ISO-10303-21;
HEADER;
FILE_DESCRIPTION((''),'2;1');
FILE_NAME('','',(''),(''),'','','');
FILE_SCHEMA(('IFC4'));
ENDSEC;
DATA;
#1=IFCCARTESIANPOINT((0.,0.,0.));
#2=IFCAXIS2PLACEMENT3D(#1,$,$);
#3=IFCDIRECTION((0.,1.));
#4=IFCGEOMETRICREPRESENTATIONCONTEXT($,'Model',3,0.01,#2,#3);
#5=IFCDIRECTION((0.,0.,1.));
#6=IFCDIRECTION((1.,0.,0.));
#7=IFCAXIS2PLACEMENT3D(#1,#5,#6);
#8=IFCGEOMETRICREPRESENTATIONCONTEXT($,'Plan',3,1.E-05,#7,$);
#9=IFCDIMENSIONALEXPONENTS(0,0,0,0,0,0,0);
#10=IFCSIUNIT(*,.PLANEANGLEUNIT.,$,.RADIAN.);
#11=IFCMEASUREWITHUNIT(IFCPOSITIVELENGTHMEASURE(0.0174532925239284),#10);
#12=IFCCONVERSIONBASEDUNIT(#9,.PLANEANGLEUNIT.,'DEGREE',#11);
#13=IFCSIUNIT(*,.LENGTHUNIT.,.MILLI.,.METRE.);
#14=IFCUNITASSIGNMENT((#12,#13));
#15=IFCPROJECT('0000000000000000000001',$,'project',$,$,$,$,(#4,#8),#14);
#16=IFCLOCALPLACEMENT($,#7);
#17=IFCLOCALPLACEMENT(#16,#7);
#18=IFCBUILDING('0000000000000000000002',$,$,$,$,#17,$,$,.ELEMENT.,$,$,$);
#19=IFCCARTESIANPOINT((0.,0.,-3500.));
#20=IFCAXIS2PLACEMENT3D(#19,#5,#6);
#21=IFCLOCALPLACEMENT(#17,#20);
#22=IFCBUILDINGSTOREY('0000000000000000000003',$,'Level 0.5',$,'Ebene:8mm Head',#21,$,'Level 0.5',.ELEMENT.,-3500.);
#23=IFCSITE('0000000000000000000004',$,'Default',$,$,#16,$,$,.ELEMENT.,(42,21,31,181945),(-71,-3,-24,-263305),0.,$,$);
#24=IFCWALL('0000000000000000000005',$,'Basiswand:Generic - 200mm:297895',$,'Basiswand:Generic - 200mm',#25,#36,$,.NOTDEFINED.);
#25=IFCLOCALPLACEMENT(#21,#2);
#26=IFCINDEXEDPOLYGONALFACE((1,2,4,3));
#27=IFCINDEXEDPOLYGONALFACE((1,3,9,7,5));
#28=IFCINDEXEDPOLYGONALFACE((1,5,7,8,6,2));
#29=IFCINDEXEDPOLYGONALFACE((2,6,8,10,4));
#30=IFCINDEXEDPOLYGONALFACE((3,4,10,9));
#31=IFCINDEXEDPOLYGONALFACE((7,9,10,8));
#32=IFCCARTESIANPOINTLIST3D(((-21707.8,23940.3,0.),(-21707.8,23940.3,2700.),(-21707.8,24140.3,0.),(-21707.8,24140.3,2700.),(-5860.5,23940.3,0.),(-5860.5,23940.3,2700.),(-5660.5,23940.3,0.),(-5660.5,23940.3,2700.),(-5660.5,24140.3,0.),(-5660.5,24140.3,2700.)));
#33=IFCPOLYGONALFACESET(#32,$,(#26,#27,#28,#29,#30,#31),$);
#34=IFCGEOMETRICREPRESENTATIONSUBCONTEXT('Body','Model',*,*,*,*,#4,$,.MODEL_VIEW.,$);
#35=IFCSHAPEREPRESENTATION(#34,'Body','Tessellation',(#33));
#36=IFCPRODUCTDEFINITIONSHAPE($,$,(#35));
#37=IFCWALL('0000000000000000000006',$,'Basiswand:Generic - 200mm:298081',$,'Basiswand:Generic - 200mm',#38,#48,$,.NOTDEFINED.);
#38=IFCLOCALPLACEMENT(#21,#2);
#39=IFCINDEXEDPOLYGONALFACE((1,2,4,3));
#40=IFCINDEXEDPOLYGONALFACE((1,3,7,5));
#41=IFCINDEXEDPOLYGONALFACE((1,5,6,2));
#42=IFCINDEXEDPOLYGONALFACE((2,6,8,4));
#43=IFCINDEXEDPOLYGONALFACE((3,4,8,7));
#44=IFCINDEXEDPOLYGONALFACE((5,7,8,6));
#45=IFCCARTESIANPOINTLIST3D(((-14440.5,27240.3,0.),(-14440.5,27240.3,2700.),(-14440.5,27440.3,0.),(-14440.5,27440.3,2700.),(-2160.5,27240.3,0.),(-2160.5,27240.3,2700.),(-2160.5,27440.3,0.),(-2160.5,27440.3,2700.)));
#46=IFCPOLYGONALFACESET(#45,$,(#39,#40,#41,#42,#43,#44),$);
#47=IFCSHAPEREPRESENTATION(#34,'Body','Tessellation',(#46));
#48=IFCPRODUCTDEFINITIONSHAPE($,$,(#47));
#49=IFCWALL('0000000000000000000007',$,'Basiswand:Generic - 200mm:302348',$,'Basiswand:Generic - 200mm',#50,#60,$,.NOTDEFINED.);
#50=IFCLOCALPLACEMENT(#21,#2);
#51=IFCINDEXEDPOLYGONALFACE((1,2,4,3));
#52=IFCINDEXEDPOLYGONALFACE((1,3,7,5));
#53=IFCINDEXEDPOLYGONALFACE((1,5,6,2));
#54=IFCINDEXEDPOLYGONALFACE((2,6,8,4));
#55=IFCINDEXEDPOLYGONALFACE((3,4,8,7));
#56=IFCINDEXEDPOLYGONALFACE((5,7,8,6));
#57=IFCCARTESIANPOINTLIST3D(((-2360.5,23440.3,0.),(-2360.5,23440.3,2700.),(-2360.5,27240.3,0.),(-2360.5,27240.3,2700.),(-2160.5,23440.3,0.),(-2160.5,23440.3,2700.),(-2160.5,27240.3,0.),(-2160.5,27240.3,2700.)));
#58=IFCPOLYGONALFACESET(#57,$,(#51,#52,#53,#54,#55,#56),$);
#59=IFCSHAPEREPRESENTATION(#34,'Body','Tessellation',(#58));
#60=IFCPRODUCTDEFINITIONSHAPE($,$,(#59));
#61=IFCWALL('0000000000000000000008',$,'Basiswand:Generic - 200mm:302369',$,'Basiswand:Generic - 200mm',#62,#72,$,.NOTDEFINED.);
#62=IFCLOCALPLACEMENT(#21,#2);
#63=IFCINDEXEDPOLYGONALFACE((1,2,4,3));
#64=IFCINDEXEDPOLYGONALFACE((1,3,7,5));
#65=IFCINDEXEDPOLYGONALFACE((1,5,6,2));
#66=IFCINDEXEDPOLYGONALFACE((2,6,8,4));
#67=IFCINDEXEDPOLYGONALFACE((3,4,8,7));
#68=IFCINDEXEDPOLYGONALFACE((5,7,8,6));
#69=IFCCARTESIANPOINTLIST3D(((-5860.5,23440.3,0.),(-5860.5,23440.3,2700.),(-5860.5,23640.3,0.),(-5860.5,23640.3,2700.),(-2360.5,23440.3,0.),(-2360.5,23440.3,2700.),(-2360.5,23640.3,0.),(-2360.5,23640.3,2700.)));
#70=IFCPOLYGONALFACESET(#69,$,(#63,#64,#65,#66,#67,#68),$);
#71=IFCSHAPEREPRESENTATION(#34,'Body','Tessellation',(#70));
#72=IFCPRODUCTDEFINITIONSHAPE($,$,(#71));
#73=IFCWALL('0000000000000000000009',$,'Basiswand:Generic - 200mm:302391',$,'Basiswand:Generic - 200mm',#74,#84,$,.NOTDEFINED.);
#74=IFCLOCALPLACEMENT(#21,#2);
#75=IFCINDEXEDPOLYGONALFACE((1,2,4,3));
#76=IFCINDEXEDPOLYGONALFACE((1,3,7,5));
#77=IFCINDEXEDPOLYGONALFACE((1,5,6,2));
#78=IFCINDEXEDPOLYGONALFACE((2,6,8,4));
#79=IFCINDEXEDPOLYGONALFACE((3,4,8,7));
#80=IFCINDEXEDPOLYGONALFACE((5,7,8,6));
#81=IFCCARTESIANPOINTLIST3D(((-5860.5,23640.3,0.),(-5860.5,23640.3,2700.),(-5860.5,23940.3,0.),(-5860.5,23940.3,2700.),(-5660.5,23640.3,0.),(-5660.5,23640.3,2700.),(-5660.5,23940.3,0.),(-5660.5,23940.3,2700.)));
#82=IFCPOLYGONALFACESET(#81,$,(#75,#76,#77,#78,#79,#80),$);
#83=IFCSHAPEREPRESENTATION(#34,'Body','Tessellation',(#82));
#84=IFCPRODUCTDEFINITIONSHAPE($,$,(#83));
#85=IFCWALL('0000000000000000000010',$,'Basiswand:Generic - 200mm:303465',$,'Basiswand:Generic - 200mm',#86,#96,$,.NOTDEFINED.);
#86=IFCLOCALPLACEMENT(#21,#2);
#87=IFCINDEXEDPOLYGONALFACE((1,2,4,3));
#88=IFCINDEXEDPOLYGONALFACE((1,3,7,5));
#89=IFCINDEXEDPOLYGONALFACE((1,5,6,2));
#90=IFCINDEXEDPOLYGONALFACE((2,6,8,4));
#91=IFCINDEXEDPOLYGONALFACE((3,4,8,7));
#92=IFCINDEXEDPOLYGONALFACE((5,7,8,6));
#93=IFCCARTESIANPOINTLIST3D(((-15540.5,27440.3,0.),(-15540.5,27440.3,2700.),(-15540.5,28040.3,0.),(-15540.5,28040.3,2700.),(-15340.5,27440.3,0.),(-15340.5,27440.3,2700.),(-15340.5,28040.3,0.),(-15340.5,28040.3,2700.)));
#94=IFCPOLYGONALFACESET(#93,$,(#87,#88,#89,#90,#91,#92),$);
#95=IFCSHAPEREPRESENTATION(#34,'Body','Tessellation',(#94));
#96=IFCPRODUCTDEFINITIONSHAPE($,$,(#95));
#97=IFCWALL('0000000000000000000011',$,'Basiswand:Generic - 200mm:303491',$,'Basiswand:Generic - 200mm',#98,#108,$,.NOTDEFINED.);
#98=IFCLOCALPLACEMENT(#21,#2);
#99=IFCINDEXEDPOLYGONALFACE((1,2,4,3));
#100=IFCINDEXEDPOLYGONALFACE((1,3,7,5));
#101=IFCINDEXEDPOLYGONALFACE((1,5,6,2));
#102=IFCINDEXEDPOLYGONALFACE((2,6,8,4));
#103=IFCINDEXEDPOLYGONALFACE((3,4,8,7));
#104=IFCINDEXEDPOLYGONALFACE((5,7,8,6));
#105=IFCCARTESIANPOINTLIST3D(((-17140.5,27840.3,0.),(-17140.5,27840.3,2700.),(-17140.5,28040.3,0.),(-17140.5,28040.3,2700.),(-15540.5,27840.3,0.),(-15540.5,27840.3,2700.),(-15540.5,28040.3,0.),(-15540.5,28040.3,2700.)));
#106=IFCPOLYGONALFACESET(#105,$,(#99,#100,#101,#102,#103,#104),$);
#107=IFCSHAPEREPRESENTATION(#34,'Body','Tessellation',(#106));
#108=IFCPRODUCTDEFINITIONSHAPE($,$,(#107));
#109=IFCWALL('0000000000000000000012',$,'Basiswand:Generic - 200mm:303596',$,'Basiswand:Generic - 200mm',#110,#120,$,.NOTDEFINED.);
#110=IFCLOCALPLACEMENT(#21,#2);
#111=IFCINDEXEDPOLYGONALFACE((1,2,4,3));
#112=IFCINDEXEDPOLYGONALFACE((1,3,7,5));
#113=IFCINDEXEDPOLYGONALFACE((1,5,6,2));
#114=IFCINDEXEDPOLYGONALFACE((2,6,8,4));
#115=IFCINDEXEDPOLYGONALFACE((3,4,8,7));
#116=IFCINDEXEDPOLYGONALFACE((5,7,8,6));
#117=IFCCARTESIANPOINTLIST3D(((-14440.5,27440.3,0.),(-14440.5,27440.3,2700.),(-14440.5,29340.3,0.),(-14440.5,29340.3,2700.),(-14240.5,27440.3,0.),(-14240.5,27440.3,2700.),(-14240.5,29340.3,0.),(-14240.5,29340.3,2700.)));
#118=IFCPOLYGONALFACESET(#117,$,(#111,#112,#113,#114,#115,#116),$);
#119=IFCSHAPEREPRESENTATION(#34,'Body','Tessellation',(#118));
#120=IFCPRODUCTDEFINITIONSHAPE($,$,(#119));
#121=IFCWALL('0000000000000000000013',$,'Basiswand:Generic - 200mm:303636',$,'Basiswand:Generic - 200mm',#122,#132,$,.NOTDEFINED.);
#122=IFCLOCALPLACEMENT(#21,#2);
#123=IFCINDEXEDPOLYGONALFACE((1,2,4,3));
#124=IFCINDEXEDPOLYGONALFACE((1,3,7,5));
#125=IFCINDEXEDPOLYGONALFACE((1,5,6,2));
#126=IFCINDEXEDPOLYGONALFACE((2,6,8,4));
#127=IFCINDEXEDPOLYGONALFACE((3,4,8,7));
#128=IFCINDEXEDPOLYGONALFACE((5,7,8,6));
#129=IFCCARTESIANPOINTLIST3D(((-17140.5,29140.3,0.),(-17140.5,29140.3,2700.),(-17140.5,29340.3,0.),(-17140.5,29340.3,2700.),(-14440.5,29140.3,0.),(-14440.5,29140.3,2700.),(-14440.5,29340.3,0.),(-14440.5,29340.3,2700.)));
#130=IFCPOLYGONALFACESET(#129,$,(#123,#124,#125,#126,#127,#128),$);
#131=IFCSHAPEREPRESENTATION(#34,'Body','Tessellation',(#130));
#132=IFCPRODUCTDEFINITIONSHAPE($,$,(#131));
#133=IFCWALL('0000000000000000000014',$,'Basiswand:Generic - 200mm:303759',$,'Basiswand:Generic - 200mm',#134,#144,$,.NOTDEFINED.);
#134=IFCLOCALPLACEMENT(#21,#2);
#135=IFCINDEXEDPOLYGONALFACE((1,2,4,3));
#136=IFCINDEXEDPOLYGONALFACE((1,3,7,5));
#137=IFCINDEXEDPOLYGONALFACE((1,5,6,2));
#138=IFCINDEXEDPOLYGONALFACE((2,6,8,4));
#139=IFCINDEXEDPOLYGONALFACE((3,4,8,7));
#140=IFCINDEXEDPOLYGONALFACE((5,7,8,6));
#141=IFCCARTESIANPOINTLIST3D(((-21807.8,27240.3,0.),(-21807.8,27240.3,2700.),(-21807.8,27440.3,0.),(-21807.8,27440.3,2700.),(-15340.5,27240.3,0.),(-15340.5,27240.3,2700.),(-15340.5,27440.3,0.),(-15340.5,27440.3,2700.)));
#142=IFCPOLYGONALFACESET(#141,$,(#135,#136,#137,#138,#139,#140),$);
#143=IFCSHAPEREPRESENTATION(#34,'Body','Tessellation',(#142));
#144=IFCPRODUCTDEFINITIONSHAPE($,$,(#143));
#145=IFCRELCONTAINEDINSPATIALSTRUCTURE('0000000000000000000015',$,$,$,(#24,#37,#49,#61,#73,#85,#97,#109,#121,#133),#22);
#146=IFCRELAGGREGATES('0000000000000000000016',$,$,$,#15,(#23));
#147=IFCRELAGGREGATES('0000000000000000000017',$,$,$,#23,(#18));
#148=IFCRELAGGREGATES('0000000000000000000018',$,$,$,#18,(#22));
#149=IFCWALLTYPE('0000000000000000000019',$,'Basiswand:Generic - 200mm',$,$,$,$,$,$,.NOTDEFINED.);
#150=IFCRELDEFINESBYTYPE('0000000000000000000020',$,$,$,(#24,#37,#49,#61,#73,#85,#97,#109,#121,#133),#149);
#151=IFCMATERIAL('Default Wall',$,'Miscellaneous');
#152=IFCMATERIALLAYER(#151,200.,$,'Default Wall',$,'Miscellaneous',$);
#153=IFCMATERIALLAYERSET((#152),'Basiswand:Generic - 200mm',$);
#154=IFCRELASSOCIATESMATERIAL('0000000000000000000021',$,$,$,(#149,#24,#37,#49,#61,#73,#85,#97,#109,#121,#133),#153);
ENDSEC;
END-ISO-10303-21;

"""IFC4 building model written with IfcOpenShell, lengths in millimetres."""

from ifc_helpers import new_model, entity, si_unit, converted_unit, direction, frame, origin, origin_with_axes, place, context, subcontext, project, spatial, indexed_curve, outline, extrude, material, layer, layer_set, type_object, element, save


model = new_model("IFC4")

# Units and contexts
model_context = context("Model", 3, precision=0.01, world=origin(), true_north=direction((0.0, 1.0)))
plan_context = context("Plan", 3, precision=1e-05, world=origin_with_axes())
body_context = subcontext(model_context, "Body", "Model", "MODEL_VIEW")
ifc_project = project(units=[converted_unit("PLANEANGLEUNIT", "DEGREE", entity("IfcPositiveLengthMeasure", 0.0174532925239284), si_unit("PLANEANGLEUNIT", "RADIAN"), dimensions=[0, 0, 0, 0, 0, 0, 0]), si_unit("LENGTHUNIT", "METRE", prefix="MILLI")], contexts=[model_context, plan_context])

# Site, building, storey
site_placement = place(None, origin_with_axes())
site = spatial("IfcSite", under=ifc_project, at=site_placement, Name="Default", CompositionType="ELEMENT", RefLatitude=(42, 21, 31, 181945), RefLongitude=(-71, -3, -24, -263305), RefElevation=0.0)
building_placement = place(site_placement, origin_with_axes())
building = spatial("IfcBuilding", under=site, at=building_placement, CompositionType="ELEMENT")
storey_placement = place(building_placement, frame((0.0, 0.0, -3500.0), z_axis=(0.0, 0.0, 1.0), x_axis=(1.0, 0.0, 0.0)))
storey = spatial("IfcBuildingStorey", under=building, at=storey_placement, Name="Level 0.5", ObjectType="Ebene:8mm Head", LongName="Level 0.5", CompositionType="ELEMENT", Elevation=-3500.0)

# Walls
ifc_material_1 = material(Name="Default Wall", Category="Miscellaneous")
ifc_layer_1 = layer(ifc_material_1, 200.0, Name="Default Wall", Category="Miscellaneous")
ifc_layer_set_1 = layer_set([ifc_layer_1], Name="Basiswand:Generic - 200mm")
wall_type = type_object("IfcWallType", Name="Basiswand:Generic - 200mm", PredefinedType="NOTDEFINED", material=ifc_layer_set_1)
wall_1_placement = place(storey_placement, frame((-21707.8, 24040.3, 0.0), z_axis=(0.0, 0.0, 1.0), x_axis=(1.0, 0.0, 0.0)))
element("IfcWall", 1, at=wall_1_placement, inside=storey, type_object=wall_type, material=ifc_layer_set_1, Name="Basiswand:Generic - 200mm:297895", ObjectType="Basiswand:Generic - 200mm", PredefinedType="NOTDEFINED", context=body_context, shape_type="SweptSolid", body=[
    extrude(outline(indexed_curve([(16047.3, -100.0), (16047.3, 100.0), (0.0, 100.0), (0.0, -100.0), (15847.3, -100.0), (16047.3, -100.0)], self_intersect=False)), origin(), (0.0, 0.0, 1.0), 2700.0),
])
wall_2_placement = place(storey_placement, frame((-2160.5, 27340.3, 0.0), z_axis=(0.0, 0.0, 1.0), x_axis=(-1.0, 0.0, 0.0)))
element("IfcWall", 2, at=wall_2_placement, inside=storey, type_object=wall_type, material=ifc_layer_set_1, Name="Basiswand:Generic - 200mm:298081", ObjectType="Basiswand:Generic - 200mm", PredefinedType="NOTDEFINED", context=body_context, shape_type="SweptSolid", body=[
    extrude(outline(indexed_curve([(12280.0, 100.0), (0.0, 100.0), (0.0, -100.0), (12280.0, -100.0), (12280.0, 100.0)], self_intersect=False)), origin(), (0.0, 0.0, 1.0), 2700.0),
])
wall_3_placement = place(storey_placement, frame((-2260.5, 27240.3, 0.0), z_axis=(0.0, 0.0, 1.0), x_axis=(0.0, -1.0, 0.0)))
element("IfcWall", 3, at=wall_3_placement, inside=storey, type_object=wall_type, material=ifc_layer_set_1, Name="Basiswand:Generic - 200mm:302348", ObjectType="Basiswand:Generic - 200mm", PredefinedType="NOTDEFINED", context=body_context, shape_type="SweptSolid", body=[
    extrude(outline(indexed_curve([(3800.0, 100.0), (0.0, 100.0), (0.0, -100.0), (3800.0, -100.0), (3800.0, 100.0)], self_intersect=False)), origin(), (0.0, 0.0, 1.0), 2700.0),
])
wall_4_placement = place(storey_placement, frame((-2360.5, 23540.3, 0.0), z_axis=(0.0, 0.0, 1.0), x_axis=(-1.0, 0.0, 0.0)))
element("IfcWall", 4, at=wall_4_placement, inside=storey, type_object=wall_type, material=ifc_layer_set_1, Name="Basiswand:Generic - 200mm:302369", ObjectType="Basiswand:Generic - 200mm", PredefinedType="NOTDEFINED", context=body_context, shape_type="SweptSolid", body=[
    extrude(outline(indexed_curve([(3500.0, 100.0), (0.0, 100.0), (0.0, -100.0), (3500.0, -100.0), (3500.0, 100.0)], self_intersect=False)), origin(), (0.0, 0.0, 1.0), 2700.0),
])
wall_5_placement = place(storey_placement, frame((-5760.5, 23640.3, 0.0), z_axis=(0.0, 0.0, 1.0), x_axis=(0.0, 1.0, 0.0)))
element("IfcWall", 5, at=wall_5_placement, inside=storey, type_object=wall_type, material=ifc_layer_set_1, Name="Basiswand:Generic - 200mm:302391", ObjectType="Basiswand:Generic - 200mm", PredefinedType="NOTDEFINED", context=body_context, shape_type="SweptSolid", body=[
    extrude(outline(indexed_curve([(300.0, 100.0), (0.0, 100.0), (0.0, -100.0), (300.0, -100.0), (300.0, 100.0)], self_intersect=False)), origin(), (0.0, 0.0, 1.0), 2700.0),
])
wall_6_placement = place(storey_placement, frame((-15440.5, 27440.3, 0.0), z_axis=(0.0, 0.0, 1.0), x_axis=(0.0, 1.0, 0.0)))
element("IfcWall", 6, at=wall_6_placement, inside=storey, type_object=wall_type, material=ifc_layer_set_1, Name="Basiswand:Generic - 200mm:303465", ObjectType="Basiswand:Generic - 200mm", PredefinedType="NOTDEFINED", context=body_context, shape_type="SweptSolid", body=[
    extrude(outline(indexed_curve([(600.0, 100.0), (0.0, 100.0), (0.0, -100.0), (600.0, -100.0), (600.0, 100.0)], self_intersect=False)), origin(), (0.0, 0.0, 1.0), 2700.0),
])
wall_7_placement = place(storey_placement, frame((-15540.5, 27940.3, 0.0), z_axis=(0.0, 0.0, 1.0), x_axis=(-1.0, 0.0, 0.0)))
element("IfcWall", 7, at=wall_7_placement, inside=storey, type_object=wall_type, material=ifc_layer_set_1, Name="Basiswand:Generic - 200mm:303491", ObjectType="Basiswand:Generic - 200mm", PredefinedType="NOTDEFINED", context=body_context, shape_type="SweptSolid", body=[
    extrude(outline(indexed_curve([(1600.0, 100.0), (0.0, 100.0), (0.0, -100.0), (1600.0, -100.0), (1600.0, 100.0)], self_intersect=False)), origin(), (0.0, 0.0, 1.0), 2700.0),
])
wall_8_placement = place(storey_placement, frame((-14340.5, 27440.3, 0.0), z_axis=(0.0, 0.0, 1.0), x_axis=(0.0, 1.0, 0.0)))
element("IfcWall", 8, at=wall_8_placement, inside=storey, type_object=wall_type, material=ifc_layer_set_1, Name="Basiswand:Generic - 200mm:303596", ObjectType="Basiswand:Generic - 200mm", PredefinedType="NOTDEFINED", context=body_context, shape_type="SweptSolid", body=[
    extrude(outline(indexed_curve([(1900.0, 100.0), (0.0, 100.0), (0.0, -100.0), (1900.0, -100.0), (1900.0, 100.0)], self_intersect=False)), origin(), (0.0, 0.0, 1.0), 2700.0),
])
wall_9_placement = place(storey_placement, frame((-14440.5, 29240.3, 0.0), z_axis=(0.0, 0.0, 1.0), x_axis=(-1.0, 0.0, 0.0)))
element("IfcWall", 9, at=wall_9_placement, inside=storey, type_object=wall_type, material=ifc_layer_set_1, Name="Basiswand:Generic - 200mm:303636", ObjectType="Basiswand:Generic - 200mm", PredefinedType="NOTDEFINED", context=body_context, shape_type="SweptSolid", body=[
    extrude(outline(indexed_curve([(2700.0, 100.0), (0.0, 100.0), (0.0, -100.0), (2700.0, -100.0), (2700.0, 100.0)], self_intersect=False)), origin(), (0.0, 0.0, 1.0), 2700.0),
])
wall_10_placement = place(storey_placement, frame((-15340.5, 27340.3, 0.0), z_axis=(0.0, 0.0, 1.0), x_axis=(-1.0, 0.0, 0.0)))
element("IfcWall", 10, at=wall_10_placement, inside=storey, type_object=wall_type, material=ifc_layer_set_1, Name="Basiswand:Generic - 200mm:303759", ObjectType="Basiswand:Generic - 200mm", PredefinedType="NOTDEFINED", context=body_context, shape_type="SweptSolid", body=[
    extrude(outline(indexed_curve([(6467.3, 100.0), (0.0, 100.0), (0.0, -100.0), (6467.3, -100.0), (6467.3, 100.0)], self_intersect=False)), origin(), (0.0, 0.0, 1.0), 2700.0),
])

save(model, "model.ifc")
